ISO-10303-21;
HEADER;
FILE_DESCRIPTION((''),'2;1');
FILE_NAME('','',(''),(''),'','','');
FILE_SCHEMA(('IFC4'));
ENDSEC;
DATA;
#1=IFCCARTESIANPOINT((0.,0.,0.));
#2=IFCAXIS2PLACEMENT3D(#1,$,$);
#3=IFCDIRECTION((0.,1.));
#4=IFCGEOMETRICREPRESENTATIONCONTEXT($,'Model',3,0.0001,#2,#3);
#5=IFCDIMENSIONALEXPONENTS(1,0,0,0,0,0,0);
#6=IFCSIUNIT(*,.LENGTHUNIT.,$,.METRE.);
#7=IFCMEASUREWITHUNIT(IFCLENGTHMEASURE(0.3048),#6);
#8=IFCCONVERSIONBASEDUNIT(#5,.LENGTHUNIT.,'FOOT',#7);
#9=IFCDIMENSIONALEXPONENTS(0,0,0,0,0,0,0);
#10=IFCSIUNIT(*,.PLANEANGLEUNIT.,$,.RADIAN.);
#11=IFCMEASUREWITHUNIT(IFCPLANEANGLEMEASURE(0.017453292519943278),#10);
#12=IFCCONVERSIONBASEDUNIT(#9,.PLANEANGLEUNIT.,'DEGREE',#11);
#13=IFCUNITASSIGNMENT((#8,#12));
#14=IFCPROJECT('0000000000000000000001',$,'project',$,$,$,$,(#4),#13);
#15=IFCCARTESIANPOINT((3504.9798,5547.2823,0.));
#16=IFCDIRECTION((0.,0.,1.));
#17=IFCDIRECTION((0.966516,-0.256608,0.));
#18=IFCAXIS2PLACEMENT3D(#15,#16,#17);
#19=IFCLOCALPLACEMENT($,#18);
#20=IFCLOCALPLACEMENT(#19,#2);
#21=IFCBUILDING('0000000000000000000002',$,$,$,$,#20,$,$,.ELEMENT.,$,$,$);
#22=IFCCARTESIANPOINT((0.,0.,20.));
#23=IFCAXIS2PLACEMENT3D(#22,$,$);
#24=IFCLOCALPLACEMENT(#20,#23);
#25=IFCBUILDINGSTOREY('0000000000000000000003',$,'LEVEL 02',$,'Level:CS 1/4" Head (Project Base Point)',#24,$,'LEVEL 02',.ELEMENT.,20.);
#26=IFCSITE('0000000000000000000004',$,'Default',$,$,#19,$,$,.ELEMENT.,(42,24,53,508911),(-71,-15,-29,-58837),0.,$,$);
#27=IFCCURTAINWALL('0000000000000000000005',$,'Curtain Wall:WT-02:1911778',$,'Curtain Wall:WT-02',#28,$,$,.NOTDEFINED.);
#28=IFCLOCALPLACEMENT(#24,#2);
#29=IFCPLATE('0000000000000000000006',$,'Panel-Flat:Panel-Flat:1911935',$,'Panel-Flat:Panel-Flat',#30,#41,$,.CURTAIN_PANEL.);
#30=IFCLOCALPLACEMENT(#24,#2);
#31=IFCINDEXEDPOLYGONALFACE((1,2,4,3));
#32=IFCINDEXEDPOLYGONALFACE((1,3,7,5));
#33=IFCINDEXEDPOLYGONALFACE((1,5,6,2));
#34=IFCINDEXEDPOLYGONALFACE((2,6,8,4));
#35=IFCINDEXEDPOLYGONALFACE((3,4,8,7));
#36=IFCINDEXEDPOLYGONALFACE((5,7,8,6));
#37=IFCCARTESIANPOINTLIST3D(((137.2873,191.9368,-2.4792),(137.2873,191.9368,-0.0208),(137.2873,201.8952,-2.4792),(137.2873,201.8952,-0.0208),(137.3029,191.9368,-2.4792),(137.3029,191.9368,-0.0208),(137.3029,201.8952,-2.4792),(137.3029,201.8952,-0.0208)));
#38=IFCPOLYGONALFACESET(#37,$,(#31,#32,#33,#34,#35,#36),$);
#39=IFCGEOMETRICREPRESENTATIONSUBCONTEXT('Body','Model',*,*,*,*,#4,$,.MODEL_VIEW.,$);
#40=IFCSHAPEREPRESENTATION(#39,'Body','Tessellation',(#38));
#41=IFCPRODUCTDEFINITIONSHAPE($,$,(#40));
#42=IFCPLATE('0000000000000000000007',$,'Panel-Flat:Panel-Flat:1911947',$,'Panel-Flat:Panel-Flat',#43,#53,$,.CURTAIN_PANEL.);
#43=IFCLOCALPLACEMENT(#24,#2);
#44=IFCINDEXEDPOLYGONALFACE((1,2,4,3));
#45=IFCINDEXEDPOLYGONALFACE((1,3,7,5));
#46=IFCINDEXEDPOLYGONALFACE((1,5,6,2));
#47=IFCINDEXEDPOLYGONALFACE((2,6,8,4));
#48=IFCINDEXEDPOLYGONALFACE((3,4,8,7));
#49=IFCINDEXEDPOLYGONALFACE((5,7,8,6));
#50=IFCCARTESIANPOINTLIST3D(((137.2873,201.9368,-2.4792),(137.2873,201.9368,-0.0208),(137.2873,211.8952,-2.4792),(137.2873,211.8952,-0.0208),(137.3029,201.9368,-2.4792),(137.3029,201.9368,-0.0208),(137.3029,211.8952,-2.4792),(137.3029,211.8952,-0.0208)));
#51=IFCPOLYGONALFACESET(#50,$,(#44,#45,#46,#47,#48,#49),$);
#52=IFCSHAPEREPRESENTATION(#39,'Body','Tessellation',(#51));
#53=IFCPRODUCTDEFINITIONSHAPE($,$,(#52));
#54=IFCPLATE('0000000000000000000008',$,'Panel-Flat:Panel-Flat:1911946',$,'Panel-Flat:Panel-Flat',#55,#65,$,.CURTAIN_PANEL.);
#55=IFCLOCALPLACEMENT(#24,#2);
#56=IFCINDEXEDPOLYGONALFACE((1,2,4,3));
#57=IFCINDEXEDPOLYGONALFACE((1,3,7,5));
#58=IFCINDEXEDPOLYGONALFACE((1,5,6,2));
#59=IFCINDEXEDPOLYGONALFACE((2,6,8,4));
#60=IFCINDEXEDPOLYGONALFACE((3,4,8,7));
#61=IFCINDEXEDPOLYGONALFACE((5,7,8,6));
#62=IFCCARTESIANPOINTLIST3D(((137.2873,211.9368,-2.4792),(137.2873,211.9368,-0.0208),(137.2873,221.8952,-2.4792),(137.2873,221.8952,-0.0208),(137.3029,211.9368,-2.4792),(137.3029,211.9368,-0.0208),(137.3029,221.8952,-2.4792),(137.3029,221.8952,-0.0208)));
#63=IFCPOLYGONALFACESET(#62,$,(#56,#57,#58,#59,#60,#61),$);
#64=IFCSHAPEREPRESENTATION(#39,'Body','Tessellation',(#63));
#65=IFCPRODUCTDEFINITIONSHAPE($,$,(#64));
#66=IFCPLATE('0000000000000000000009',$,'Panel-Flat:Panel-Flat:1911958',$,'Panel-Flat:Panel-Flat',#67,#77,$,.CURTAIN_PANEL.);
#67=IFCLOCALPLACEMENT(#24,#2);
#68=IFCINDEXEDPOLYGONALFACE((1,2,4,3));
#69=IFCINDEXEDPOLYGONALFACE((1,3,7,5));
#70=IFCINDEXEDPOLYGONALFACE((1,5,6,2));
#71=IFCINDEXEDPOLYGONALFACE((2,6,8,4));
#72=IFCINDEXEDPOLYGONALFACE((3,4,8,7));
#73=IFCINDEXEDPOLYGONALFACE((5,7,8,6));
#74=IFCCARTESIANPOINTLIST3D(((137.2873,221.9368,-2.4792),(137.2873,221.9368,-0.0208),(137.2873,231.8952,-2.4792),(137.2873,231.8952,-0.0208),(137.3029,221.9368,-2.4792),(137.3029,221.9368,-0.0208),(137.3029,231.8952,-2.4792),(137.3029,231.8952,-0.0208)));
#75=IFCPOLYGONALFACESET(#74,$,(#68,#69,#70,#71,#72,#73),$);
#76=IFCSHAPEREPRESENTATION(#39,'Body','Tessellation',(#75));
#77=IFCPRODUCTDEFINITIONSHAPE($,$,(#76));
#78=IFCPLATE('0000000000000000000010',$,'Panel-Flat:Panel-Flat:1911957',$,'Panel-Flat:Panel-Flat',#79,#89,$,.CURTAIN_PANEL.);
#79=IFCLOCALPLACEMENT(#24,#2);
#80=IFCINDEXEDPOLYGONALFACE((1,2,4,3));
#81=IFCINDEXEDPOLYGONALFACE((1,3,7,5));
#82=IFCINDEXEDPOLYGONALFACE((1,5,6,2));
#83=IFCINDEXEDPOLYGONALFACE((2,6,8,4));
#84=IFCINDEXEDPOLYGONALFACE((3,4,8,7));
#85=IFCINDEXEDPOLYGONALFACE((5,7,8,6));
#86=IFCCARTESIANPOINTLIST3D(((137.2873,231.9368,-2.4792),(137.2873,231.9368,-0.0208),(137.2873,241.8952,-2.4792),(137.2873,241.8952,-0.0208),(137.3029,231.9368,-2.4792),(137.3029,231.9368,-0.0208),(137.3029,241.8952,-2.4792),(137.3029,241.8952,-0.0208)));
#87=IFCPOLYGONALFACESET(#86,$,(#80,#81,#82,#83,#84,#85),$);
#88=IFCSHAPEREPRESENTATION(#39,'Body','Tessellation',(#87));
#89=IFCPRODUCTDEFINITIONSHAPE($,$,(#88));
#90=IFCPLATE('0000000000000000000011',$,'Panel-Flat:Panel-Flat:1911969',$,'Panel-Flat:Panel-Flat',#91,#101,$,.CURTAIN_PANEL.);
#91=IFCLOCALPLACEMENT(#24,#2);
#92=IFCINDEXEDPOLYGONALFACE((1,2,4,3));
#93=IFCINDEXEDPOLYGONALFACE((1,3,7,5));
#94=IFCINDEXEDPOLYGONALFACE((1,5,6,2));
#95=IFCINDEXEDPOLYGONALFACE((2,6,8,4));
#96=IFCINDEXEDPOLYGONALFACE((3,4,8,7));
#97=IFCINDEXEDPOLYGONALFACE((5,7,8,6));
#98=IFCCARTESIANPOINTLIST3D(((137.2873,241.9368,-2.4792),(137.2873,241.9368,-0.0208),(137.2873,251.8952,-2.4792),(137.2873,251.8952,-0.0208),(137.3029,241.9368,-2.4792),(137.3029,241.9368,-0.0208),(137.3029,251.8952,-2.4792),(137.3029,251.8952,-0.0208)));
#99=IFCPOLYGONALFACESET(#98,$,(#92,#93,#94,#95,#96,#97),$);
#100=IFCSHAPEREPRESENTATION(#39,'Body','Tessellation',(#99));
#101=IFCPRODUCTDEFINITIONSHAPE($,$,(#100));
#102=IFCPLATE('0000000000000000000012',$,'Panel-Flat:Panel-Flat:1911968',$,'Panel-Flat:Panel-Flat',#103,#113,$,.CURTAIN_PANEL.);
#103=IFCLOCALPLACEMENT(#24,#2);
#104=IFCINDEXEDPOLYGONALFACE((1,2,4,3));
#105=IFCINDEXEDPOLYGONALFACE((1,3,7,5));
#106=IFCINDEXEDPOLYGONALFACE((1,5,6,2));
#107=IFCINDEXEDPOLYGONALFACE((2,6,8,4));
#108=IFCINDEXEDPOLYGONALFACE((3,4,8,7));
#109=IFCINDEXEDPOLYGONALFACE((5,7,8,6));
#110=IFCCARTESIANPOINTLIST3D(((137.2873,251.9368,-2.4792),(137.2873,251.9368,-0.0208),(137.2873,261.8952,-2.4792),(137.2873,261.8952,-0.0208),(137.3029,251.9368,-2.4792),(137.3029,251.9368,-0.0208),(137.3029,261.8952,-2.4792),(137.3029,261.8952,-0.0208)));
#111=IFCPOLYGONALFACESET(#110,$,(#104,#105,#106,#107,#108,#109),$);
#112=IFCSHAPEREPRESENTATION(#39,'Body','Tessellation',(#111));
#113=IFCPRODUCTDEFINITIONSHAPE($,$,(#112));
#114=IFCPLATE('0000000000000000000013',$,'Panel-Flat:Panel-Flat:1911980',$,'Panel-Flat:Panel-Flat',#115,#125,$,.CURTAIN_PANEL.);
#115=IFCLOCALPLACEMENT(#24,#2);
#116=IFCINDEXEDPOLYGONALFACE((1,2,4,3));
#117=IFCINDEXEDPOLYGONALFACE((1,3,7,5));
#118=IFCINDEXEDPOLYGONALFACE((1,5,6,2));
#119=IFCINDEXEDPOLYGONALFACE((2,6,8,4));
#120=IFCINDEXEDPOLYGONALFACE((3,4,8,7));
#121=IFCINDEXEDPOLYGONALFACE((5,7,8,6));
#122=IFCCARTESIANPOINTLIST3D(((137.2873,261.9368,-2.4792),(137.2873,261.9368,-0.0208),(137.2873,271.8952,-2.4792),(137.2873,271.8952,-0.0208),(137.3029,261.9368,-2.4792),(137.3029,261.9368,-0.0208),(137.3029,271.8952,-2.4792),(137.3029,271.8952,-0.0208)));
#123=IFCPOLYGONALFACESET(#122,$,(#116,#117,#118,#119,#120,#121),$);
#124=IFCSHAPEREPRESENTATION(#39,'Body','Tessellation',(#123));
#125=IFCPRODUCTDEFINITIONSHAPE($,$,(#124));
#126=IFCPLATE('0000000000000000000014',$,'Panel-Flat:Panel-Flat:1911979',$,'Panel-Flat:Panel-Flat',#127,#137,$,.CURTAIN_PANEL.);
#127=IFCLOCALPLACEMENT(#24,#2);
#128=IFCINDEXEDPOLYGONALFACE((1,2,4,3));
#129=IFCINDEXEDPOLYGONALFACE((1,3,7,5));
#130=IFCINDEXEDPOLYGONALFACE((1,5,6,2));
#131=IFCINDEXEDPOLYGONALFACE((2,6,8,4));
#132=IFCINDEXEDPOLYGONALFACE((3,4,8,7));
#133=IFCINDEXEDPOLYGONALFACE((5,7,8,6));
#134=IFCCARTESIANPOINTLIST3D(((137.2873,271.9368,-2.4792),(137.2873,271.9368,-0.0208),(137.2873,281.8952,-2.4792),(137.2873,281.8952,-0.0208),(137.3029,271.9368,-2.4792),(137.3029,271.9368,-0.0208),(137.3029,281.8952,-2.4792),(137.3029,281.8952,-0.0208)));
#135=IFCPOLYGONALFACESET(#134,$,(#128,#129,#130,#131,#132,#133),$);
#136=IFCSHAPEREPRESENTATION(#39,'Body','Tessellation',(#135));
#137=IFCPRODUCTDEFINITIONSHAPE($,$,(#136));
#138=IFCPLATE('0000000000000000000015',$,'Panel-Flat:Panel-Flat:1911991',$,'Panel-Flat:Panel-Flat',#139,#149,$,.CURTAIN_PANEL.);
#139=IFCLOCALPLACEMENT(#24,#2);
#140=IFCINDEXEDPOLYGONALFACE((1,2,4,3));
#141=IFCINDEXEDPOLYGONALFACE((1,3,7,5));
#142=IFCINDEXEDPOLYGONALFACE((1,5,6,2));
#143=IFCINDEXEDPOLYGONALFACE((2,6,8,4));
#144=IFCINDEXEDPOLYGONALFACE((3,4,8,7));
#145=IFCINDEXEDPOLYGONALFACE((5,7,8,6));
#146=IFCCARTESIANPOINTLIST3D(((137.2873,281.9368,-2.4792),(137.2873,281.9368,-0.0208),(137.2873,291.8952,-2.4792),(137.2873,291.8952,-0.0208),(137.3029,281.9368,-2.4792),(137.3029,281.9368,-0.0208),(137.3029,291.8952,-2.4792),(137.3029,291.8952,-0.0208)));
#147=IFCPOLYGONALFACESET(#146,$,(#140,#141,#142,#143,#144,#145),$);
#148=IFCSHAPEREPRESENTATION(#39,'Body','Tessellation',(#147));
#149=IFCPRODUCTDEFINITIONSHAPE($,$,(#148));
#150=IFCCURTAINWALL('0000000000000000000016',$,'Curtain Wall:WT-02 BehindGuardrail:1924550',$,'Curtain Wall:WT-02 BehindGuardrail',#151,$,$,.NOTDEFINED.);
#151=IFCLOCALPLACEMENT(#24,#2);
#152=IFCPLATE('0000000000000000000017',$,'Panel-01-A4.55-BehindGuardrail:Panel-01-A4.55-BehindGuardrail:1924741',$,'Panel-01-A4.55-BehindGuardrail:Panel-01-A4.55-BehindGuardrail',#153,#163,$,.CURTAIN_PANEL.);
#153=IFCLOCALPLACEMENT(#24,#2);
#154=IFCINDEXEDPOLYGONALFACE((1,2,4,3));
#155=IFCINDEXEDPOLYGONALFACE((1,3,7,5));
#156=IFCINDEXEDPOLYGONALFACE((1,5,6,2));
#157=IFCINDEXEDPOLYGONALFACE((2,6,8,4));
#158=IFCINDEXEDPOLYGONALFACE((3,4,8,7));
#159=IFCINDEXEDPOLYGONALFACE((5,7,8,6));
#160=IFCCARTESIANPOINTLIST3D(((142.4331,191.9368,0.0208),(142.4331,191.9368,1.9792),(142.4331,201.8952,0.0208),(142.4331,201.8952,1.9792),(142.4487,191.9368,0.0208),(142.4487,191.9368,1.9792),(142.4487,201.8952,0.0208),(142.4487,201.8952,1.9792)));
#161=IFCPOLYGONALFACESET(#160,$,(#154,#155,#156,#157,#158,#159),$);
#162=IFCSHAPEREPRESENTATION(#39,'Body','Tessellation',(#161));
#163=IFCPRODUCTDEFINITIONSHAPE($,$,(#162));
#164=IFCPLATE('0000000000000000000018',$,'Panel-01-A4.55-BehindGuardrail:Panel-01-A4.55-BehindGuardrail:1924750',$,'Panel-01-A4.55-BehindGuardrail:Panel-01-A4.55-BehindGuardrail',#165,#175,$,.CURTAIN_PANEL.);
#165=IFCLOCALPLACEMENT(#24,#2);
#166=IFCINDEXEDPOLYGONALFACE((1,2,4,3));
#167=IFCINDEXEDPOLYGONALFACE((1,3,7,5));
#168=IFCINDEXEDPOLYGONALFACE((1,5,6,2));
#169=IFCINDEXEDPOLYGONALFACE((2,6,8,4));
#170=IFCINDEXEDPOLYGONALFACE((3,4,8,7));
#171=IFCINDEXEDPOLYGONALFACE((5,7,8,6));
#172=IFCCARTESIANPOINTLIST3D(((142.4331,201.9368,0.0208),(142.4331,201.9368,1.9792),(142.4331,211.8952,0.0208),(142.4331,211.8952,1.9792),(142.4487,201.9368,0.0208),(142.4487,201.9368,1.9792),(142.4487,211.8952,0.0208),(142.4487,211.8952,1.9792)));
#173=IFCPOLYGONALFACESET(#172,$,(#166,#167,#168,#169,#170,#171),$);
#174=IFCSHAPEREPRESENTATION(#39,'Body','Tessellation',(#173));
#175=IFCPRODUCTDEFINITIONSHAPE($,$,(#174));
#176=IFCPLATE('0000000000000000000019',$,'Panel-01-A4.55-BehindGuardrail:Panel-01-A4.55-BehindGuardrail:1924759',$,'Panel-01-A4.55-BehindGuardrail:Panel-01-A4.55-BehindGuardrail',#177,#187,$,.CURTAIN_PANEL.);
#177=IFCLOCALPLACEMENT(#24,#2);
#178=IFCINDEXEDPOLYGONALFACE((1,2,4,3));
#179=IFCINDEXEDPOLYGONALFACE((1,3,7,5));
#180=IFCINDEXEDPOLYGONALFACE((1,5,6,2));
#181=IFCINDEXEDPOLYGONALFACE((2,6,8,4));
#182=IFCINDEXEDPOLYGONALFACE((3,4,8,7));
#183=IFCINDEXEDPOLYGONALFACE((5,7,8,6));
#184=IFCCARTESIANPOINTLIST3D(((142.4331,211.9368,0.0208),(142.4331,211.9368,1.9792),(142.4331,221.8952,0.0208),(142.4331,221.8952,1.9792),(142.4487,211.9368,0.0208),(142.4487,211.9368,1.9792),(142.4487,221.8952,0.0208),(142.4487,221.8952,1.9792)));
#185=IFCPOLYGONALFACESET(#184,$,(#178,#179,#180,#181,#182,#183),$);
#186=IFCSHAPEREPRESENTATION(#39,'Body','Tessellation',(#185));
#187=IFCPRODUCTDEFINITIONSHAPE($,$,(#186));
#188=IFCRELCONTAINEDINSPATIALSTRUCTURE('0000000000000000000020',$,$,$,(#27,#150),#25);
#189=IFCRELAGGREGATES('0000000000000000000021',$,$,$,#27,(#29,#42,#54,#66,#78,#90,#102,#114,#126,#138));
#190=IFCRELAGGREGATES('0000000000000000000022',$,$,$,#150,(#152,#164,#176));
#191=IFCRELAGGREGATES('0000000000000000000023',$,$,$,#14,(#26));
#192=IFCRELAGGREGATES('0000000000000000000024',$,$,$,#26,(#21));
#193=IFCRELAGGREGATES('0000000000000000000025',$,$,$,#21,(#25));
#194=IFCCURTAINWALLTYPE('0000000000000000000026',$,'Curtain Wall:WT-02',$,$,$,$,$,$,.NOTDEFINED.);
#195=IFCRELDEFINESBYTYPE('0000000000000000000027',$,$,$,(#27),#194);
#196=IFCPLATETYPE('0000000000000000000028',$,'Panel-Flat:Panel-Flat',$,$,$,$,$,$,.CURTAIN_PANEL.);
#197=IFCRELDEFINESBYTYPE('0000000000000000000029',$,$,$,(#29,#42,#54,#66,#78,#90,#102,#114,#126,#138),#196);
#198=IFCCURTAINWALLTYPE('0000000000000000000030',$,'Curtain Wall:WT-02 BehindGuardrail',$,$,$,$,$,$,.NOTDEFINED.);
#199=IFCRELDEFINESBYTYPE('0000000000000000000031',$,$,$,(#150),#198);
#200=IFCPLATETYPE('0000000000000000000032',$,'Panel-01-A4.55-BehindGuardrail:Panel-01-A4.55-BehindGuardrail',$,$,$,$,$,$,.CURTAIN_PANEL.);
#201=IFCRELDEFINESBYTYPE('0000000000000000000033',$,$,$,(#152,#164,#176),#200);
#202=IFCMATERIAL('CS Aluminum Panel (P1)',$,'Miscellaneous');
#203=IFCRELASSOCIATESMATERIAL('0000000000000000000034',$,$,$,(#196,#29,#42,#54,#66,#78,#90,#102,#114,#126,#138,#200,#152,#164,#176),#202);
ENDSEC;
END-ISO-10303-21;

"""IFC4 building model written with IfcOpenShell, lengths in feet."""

from ifc_helpers import new_model, entity, si_unit, converted_unit, direction, frame, origin, place, context, subcontext, project, spatial, indexed_curve, outline, extrude, source, transform, mapped, material, type_object, type_shapes, element, aggregate, save


model = new_model("IFC4")

# Units and contexts
model_context = context("Model", 3, precision=0.0001, world=origin(), true_north=direction((0.0, 1.0)))
body_context = subcontext(model_context, "Body", "Model", "MODEL_VIEW")
ifc_project = project(units=[converted_unit("LENGTHUNIT", "FOOT", entity("IfcLengthMeasure", 0.3048), si_unit("LENGTHUNIT", "METRE"), dimensions=[1, 0, 0, 0, 0, 0, 0]), converted_unit("PLANEANGLEUNIT", "DEGREE", entity("IfcPlaneAngleMeasure", 0.017453292519943278), si_unit("PLANEANGLEUNIT", "RADIAN"), dimensions=[0, 0, 0, 0, 0, 0, 0])], contexts=[model_context])

# Site, building, storey
site_placement = place(None, frame((3504.9798, 5547.2823, 0.0), z_axis=(0.0, 0.0, 1.0), x_axis=(0.966516, -0.256608, 0.0)))
site = spatial("IfcSite", under=ifc_project, at=site_placement, Name="Default", CompositionType="ELEMENT", RefLatitude=(42, 24, 53, 508911), RefLongitude=(-71, -15, -29, -58837), RefElevation=0.0)
building_placement = place(site_placement, origin())
building = spatial("IfcBuilding", under=site, at=building_placement, CompositionType="ELEMENT")
storey_placement = place(building_placement, frame((0.0, 0.0, 20.0)))
storey = spatial("IfcBuildingStorey", under=building, at=storey_placement, Name="LEVEL 02", ObjectType="Level:CS 1/4\" Head (Project Base Point)", LongName="LEVEL 02", CompositionType="ELEMENT", Elevation=20.0)

# Curtain walls, plates
curtain_wall_type_1 = type_object("IfcCurtainWallType", Name="Curtain Wall:WT-02", PredefinedType="NOTDEFINED")
curtain_wall_1_placement = place(storey_placement, frame((0.0, 0.0, -20.0)))
curtain_wall_1 = element("IfcCurtainWall", 1, at=curtain_wall_1_placement, inside=storey, type_object=curtain_wall_type_1, Name="Curtain Wall:WT-02:1911778", ObjectType="Curtain Wall:WT-02", PredefinedType="NOTDEFINED")
ifc_material_1 = material(Name="CS Aluminum Panel (P1)", Category="Miscellaneous")
plate_type_1 = type_object("IfcPlateType", Name="Panel-Flat:Panel-Flat", PredefinedType="CURTAIN_PANEL", material=ifc_material_1)
shared_shape_1 = source(origin(), body_context, "Body", "SweptSolid", [
    extrude(outline(indexed_curve([(-0.0078, -4.9792), (0.0078, -4.9792), (0.0078, 4.9792), (-0.0078, 4.9792), (-0.0078, -4.9792)], self_intersect=False)), frame((0.0, -0.0078, 0.0208), z_axis=(0.0, 0.0, 1.0), x_axis=(0.0, -1.0, 0.0)), (0.0, 0.0, 1.0), 2.4583),
])
type_shapes(plate_type_1, [shared_shape_1])
plate_1_placement = place(curtain_wall_1_placement, frame((137.2873, 196.916, 17.5), z_axis=(0.0, 0.0, 1.0), x_axis=(0.0, 1.0, 0.0)))
plate_1 = element("IfcPlate", 2, at=plate_1_placement, type_object=plate_type_1, material=ifc_material_1, Name="Panel-Flat:Panel-Flat:1911935", ObjectType="Panel-Flat:Panel-Flat", PredefinedType="CURTAIN_PANEL", context=body_context, shape_type="MappedRepresentation", body=[
    mapped(shared_shape_1, transform((0.0, 0.0, 0.0), scale=1.0)),
])
plate_2_placement = place(curtain_wall_1_placement, frame((137.2873, 206.916, 17.5), z_axis=(0.0, 0.0, 1.0), x_axis=(0.0, 1.0, 0.0)))
plate_2 = element("IfcPlate", 3, at=plate_2_placement, type_object=plate_type_1, material=ifc_material_1, Name="Panel-Flat:Panel-Flat:1911947", ObjectType="Panel-Flat:Panel-Flat", PredefinedType="CURTAIN_PANEL", context=body_context, shape_type="MappedRepresentation", body=[
    mapped(shared_shape_1, transform((0.0, 0.0, 0.0), scale=1.0)),
])
plate_3_placement = place(curtain_wall_1_placement, frame((137.2873, 216.916, 17.5), z_axis=(0.0, 0.0, 1.0), x_axis=(0.0, 1.0, 0.0)))
plate_3 = element("IfcPlate", 4, at=plate_3_placement, type_object=plate_type_1, material=ifc_material_1, Name="Panel-Flat:Panel-Flat:1911946", ObjectType="Panel-Flat:Panel-Flat", PredefinedType="CURTAIN_PANEL", context=body_context, shape_type="MappedRepresentation", body=[
    mapped(shared_shape_1, transform((0.0, 0.0, 0.0), scale=1.0)),
])
plate_4_placement = place(curtain_wall_1_placement, frame((137.2873, 226.916, 17.5), z_axis=(0.0, 0.0, 1.0), x_axis=(0.0, 1.0, 0.0)))
plate_4 = element("IfcPlate", 5, at=plate_4_placement, type_object=plate_type_1, material=ifc_material_1, Name="Panel-Flat:Panel-Flat:1911958", ObjectType="Panel-Flat:Panel-Flat", PredefinedType="CURTAIN_PANEL", context=body_context, shape_type="MappedRepresentation", body=[
    mapped(shared_shape_1, transform((0.0, 0.0, 0.0), scale=1.0)),
])
plate_5_placement = place(curtain_wall_1_placement, frame((137.2873, 236.916, 17.5), z_axis=(0.0, 0.0, 1.0), x_axis=(0.0, 1.0, 0.0)))
plate_5 = element("IfcPlate", 6, at=plate_5_placement, type_object=plate_type_1, material=ifc_material_1, Name="Panel-Flat:Panel-Flat:1911957", ObjectType="Panel-Flat:Panel-Flat", PredefinedType="CURTAIN_PANEL", context=body_context, shape_type="MappedRepresentation", body=[
    mapped(shared_shape_1, transform((0.0, 0.0, 0.0), scale=1.0)),
])
plate_6_placement = place(curtain_wall_1_placement, frame((137.2873, 246.916, 17.5), z_axis=(0.0, 0.0, 1.0), x_axis=(0.0, 1.0, 0.0)))
plate_6 = element("IfcPlate", 7, at=plate_6_placement, type_object=plate_type_1, material=ifc_material_1, Name="Panel-Flat:Panel-Flat:1911969", ObjectType="Panel-Flat:Panel-Flat", PredefinedType="CURTAIN_PANEL", context=body_context, shape_type="MappedRepresentation", body=[
    mapped(shared_shape_1, transform((0.0, 0.0, 0.0), scale=1.0)),
])
plate_7_placement = place(curtain_wall_1_placement, frame((137.2873, 256.916, 17.5), z_axis=(0.0, 0.0, 1.0), x_axis=(0.0, 1.0, 0.0)))
plate_7 = element("IfcPlate", 8, at=plate_7_placement, type_object=plate_type_1, material=ifc_material_1, Name="Panel-Flat:Panel-Flat:1911968", ObjectType="Panel-Flat:Panel-Flat", PredefinedType="CURTAIN_PANEL", context=body_context, shape_type="MappedRepresentation", body=[
    mapped(shared_shape_1, transform((0.0, 0.0, 0.0), scale=1.0)),
])
plate_8_placement = place(curtain_wall_1_placement, frame((137.2873, 266.916, 17.5), z_axis=(0.0, 0.0, 1.0), x_axis=(0.0, 1.0, 0.0)))
plate_8 = element("IfcPlate", 9, at=plate_8_placement, type_object=plate_type_1, material=ifc_material_1, Name="Panel-Flat:Panel-Flat:1911980", ObjectType="Panel-Flat:Panel-Flat", PredefinedType="CURTAIN_PANEL", context=body_context, shape_type="MappedRepresentation", body=[
    mapped(shared_shape_1, transform((0.0, 0.0, 0.0), scale=1.0)),
])
plate_9_placement = place(curtain_wall_1_placement, frame((137.2873, 276.916, 17.5), z_axis=(0.0, 0.0, 1.0), x_axis=(0.0, 1.0, 0.0)))
plate_9 = element("IfcPlate", 10, at=plate_9_placement, type_object=plate_type_1, material=ifc_material_1, Name="Panel-Flat:Panel-Flat:1911979", ObjectType="Panel-Flat:Panel-Flat", PredefinedType="CURTAIN_PANEL", context=body_context, shape_type="MappedRepresentation", body=[
    mapped(shared_shape_1, transform((0.0, 0.0, 0.0), scale=1.0)),
])
plate_10_placement = place(curtain_wall_1_placement, frame((137.2873, 286.916, 17.5), z_axis=(0.0, 0.0, 1.0), x_axis=(0.0, 1.0, 0.0)))
plate_10 = element("IfcPlate", 11, at=plate_10_placement, type_object=plate_type_1, material=ifc_material_1, Name="Panel-Flat:Panel-Flat:1911991", ObjectType="Panel-Flat:Panel-Flat", PredefinedType="CURTAIN_PANEL", context=body_context, shape_type="MappedRepresentation", body=[
    mapped(shared_shape_1, transform((0.0, 0.0, 0.0), scale=1.0)),
])
aggregate(curtain_wall_1, [plate_1, plate_2, plate_3, plate_4, plate_5, plate_6, plate_7, plate_8, plate_9, plate_10])
curtain_wall_type_2 = type_object("IfcCurtainWallType", Name="Curtain Wall:WT-02 BehindGuardrail", PredefinedType="NOTDEFINED")
curtain_wall_2_placement = place(storey_placement, frame((0.0, 0.0, -20.0)))
curtain_wall_2 = element("IfcCurtainWall", 12, at=curtain_wall_2_placement, inside=storey, type_object=curtain_wall_type_2, Name="Curtain Wall:WT-02 BehindGuardrail:1924550", ObjectType="Curtain Wall:WT-02 BehindGuardrail", PredefinedType="NOTDEFINED")
plate_type_2 = type_object("IfcPlateType", Name="Panel-01-A4.55-BehindGuardrail:Panel-01-A4.55-BehindGuardrail", PredefinedType="CURTAIN_PANEL", material=ifc_material_1)
shared_shape_2 = source(origin(), body_context, "Body", "SweptSolid", [
    extrude(outline(indexed_curve([(-0.0078, -4.9792), (0.0078, -4.9792), (0.0078, 4.9792), (-0.0078, 4.9792), (-0.0078, -4.9792)], self_intersect=False)), frame((0.0, -0.0078, 0.0208), z_axis=(0.0, 0.0, 1.0), x_axis=(0.0, -1.0, 0.0)), (0.0, 0.0, 1.0), 1.9583),
])
type_shapes(plate_type_2, [shared_shape_2])
plate_11_placement = place(curtain_wall_2_placement, frame((142.4331, 196.916, 20.0), z_axis=(0.0, 0.0, 1.0), x_axis=(0.0, 1.0, 0.0)))
plate_11 = element("IfcPlate", 13, at=plate_11_placement, type_object=plate_type_2, material=ifc_material_1, Name="Panel-01-A4.55-BehindGuardrail:Panel-01-A4.55-BehindGuardrail:1924741", ObjectType="Panel-01-A4.55-BehindGuardrail:Panel-01-A4.55-BehindGuardrail", PredefinedType="CURTAIN_PANEL", context=body_context, shape_type="MappedRepresentation", body=[
    mapped(shared_shape_2, transform((0.0, 0.0, 0.0), scale=1.0)),
])
plate_12_placement = place(curtain_wall_2_placement, frame((142.4331, 206.916, 20.0), z_axis=(0.0, 0.0, 1.0), x_axis=(0.0, 1.0, 0.0)))
plate_12 = element("IfcPlate", 14, at=plate_12_placement, type_object=plate_type_2, material=ifc_material_1, Name="Panel-01-A4.55-BehindGuardrail:Panel-01-A4.55-BehindGuardrail:1924750", ObjectType="Panel-01-A4.55-BehindGuardrail:Panel-01-A4.55-BehindGuardrail", PredefinedType="CURTAIN_PANEL", context=body_context, shape_type="MappedRepresentation", body=[
    mapped(shared_shape_2, transform((0.0, 0.0, 0.0), scale=1.0)),
])
plate_13_placement = place(curtain_wall_2_placement, frame((142.4331, 216.916, 20.0), z_axis=(0.0, 0.0, 1.0), x_axis=(0.0, 1.0, 0.0)))
plate_13 = element("IfcPlate", 15, at=plate_13_placement, type_object=plate_type_2, material=ifc_material_1, Name="Panel-01-A4.55-BehindGuardrail:Panel-01-A4.55-BehindGuardrail:1924759", ObjectType="Panel-01-A4.55-BehindGuardrail:Panel-01-A4.55-BehindGuardrail", PredefinedType="CURTAIN_PANEL", context=body_context, shape_type="MappedRepresentation", body=[
    mapped(shared_shape_2, transform((0.0, 0.0, 0.0), scale=1.0)),
])

aggregate(curtain_wall_2, [plate_11, plate_12, plate_13])

save(model, "model.ifc")
